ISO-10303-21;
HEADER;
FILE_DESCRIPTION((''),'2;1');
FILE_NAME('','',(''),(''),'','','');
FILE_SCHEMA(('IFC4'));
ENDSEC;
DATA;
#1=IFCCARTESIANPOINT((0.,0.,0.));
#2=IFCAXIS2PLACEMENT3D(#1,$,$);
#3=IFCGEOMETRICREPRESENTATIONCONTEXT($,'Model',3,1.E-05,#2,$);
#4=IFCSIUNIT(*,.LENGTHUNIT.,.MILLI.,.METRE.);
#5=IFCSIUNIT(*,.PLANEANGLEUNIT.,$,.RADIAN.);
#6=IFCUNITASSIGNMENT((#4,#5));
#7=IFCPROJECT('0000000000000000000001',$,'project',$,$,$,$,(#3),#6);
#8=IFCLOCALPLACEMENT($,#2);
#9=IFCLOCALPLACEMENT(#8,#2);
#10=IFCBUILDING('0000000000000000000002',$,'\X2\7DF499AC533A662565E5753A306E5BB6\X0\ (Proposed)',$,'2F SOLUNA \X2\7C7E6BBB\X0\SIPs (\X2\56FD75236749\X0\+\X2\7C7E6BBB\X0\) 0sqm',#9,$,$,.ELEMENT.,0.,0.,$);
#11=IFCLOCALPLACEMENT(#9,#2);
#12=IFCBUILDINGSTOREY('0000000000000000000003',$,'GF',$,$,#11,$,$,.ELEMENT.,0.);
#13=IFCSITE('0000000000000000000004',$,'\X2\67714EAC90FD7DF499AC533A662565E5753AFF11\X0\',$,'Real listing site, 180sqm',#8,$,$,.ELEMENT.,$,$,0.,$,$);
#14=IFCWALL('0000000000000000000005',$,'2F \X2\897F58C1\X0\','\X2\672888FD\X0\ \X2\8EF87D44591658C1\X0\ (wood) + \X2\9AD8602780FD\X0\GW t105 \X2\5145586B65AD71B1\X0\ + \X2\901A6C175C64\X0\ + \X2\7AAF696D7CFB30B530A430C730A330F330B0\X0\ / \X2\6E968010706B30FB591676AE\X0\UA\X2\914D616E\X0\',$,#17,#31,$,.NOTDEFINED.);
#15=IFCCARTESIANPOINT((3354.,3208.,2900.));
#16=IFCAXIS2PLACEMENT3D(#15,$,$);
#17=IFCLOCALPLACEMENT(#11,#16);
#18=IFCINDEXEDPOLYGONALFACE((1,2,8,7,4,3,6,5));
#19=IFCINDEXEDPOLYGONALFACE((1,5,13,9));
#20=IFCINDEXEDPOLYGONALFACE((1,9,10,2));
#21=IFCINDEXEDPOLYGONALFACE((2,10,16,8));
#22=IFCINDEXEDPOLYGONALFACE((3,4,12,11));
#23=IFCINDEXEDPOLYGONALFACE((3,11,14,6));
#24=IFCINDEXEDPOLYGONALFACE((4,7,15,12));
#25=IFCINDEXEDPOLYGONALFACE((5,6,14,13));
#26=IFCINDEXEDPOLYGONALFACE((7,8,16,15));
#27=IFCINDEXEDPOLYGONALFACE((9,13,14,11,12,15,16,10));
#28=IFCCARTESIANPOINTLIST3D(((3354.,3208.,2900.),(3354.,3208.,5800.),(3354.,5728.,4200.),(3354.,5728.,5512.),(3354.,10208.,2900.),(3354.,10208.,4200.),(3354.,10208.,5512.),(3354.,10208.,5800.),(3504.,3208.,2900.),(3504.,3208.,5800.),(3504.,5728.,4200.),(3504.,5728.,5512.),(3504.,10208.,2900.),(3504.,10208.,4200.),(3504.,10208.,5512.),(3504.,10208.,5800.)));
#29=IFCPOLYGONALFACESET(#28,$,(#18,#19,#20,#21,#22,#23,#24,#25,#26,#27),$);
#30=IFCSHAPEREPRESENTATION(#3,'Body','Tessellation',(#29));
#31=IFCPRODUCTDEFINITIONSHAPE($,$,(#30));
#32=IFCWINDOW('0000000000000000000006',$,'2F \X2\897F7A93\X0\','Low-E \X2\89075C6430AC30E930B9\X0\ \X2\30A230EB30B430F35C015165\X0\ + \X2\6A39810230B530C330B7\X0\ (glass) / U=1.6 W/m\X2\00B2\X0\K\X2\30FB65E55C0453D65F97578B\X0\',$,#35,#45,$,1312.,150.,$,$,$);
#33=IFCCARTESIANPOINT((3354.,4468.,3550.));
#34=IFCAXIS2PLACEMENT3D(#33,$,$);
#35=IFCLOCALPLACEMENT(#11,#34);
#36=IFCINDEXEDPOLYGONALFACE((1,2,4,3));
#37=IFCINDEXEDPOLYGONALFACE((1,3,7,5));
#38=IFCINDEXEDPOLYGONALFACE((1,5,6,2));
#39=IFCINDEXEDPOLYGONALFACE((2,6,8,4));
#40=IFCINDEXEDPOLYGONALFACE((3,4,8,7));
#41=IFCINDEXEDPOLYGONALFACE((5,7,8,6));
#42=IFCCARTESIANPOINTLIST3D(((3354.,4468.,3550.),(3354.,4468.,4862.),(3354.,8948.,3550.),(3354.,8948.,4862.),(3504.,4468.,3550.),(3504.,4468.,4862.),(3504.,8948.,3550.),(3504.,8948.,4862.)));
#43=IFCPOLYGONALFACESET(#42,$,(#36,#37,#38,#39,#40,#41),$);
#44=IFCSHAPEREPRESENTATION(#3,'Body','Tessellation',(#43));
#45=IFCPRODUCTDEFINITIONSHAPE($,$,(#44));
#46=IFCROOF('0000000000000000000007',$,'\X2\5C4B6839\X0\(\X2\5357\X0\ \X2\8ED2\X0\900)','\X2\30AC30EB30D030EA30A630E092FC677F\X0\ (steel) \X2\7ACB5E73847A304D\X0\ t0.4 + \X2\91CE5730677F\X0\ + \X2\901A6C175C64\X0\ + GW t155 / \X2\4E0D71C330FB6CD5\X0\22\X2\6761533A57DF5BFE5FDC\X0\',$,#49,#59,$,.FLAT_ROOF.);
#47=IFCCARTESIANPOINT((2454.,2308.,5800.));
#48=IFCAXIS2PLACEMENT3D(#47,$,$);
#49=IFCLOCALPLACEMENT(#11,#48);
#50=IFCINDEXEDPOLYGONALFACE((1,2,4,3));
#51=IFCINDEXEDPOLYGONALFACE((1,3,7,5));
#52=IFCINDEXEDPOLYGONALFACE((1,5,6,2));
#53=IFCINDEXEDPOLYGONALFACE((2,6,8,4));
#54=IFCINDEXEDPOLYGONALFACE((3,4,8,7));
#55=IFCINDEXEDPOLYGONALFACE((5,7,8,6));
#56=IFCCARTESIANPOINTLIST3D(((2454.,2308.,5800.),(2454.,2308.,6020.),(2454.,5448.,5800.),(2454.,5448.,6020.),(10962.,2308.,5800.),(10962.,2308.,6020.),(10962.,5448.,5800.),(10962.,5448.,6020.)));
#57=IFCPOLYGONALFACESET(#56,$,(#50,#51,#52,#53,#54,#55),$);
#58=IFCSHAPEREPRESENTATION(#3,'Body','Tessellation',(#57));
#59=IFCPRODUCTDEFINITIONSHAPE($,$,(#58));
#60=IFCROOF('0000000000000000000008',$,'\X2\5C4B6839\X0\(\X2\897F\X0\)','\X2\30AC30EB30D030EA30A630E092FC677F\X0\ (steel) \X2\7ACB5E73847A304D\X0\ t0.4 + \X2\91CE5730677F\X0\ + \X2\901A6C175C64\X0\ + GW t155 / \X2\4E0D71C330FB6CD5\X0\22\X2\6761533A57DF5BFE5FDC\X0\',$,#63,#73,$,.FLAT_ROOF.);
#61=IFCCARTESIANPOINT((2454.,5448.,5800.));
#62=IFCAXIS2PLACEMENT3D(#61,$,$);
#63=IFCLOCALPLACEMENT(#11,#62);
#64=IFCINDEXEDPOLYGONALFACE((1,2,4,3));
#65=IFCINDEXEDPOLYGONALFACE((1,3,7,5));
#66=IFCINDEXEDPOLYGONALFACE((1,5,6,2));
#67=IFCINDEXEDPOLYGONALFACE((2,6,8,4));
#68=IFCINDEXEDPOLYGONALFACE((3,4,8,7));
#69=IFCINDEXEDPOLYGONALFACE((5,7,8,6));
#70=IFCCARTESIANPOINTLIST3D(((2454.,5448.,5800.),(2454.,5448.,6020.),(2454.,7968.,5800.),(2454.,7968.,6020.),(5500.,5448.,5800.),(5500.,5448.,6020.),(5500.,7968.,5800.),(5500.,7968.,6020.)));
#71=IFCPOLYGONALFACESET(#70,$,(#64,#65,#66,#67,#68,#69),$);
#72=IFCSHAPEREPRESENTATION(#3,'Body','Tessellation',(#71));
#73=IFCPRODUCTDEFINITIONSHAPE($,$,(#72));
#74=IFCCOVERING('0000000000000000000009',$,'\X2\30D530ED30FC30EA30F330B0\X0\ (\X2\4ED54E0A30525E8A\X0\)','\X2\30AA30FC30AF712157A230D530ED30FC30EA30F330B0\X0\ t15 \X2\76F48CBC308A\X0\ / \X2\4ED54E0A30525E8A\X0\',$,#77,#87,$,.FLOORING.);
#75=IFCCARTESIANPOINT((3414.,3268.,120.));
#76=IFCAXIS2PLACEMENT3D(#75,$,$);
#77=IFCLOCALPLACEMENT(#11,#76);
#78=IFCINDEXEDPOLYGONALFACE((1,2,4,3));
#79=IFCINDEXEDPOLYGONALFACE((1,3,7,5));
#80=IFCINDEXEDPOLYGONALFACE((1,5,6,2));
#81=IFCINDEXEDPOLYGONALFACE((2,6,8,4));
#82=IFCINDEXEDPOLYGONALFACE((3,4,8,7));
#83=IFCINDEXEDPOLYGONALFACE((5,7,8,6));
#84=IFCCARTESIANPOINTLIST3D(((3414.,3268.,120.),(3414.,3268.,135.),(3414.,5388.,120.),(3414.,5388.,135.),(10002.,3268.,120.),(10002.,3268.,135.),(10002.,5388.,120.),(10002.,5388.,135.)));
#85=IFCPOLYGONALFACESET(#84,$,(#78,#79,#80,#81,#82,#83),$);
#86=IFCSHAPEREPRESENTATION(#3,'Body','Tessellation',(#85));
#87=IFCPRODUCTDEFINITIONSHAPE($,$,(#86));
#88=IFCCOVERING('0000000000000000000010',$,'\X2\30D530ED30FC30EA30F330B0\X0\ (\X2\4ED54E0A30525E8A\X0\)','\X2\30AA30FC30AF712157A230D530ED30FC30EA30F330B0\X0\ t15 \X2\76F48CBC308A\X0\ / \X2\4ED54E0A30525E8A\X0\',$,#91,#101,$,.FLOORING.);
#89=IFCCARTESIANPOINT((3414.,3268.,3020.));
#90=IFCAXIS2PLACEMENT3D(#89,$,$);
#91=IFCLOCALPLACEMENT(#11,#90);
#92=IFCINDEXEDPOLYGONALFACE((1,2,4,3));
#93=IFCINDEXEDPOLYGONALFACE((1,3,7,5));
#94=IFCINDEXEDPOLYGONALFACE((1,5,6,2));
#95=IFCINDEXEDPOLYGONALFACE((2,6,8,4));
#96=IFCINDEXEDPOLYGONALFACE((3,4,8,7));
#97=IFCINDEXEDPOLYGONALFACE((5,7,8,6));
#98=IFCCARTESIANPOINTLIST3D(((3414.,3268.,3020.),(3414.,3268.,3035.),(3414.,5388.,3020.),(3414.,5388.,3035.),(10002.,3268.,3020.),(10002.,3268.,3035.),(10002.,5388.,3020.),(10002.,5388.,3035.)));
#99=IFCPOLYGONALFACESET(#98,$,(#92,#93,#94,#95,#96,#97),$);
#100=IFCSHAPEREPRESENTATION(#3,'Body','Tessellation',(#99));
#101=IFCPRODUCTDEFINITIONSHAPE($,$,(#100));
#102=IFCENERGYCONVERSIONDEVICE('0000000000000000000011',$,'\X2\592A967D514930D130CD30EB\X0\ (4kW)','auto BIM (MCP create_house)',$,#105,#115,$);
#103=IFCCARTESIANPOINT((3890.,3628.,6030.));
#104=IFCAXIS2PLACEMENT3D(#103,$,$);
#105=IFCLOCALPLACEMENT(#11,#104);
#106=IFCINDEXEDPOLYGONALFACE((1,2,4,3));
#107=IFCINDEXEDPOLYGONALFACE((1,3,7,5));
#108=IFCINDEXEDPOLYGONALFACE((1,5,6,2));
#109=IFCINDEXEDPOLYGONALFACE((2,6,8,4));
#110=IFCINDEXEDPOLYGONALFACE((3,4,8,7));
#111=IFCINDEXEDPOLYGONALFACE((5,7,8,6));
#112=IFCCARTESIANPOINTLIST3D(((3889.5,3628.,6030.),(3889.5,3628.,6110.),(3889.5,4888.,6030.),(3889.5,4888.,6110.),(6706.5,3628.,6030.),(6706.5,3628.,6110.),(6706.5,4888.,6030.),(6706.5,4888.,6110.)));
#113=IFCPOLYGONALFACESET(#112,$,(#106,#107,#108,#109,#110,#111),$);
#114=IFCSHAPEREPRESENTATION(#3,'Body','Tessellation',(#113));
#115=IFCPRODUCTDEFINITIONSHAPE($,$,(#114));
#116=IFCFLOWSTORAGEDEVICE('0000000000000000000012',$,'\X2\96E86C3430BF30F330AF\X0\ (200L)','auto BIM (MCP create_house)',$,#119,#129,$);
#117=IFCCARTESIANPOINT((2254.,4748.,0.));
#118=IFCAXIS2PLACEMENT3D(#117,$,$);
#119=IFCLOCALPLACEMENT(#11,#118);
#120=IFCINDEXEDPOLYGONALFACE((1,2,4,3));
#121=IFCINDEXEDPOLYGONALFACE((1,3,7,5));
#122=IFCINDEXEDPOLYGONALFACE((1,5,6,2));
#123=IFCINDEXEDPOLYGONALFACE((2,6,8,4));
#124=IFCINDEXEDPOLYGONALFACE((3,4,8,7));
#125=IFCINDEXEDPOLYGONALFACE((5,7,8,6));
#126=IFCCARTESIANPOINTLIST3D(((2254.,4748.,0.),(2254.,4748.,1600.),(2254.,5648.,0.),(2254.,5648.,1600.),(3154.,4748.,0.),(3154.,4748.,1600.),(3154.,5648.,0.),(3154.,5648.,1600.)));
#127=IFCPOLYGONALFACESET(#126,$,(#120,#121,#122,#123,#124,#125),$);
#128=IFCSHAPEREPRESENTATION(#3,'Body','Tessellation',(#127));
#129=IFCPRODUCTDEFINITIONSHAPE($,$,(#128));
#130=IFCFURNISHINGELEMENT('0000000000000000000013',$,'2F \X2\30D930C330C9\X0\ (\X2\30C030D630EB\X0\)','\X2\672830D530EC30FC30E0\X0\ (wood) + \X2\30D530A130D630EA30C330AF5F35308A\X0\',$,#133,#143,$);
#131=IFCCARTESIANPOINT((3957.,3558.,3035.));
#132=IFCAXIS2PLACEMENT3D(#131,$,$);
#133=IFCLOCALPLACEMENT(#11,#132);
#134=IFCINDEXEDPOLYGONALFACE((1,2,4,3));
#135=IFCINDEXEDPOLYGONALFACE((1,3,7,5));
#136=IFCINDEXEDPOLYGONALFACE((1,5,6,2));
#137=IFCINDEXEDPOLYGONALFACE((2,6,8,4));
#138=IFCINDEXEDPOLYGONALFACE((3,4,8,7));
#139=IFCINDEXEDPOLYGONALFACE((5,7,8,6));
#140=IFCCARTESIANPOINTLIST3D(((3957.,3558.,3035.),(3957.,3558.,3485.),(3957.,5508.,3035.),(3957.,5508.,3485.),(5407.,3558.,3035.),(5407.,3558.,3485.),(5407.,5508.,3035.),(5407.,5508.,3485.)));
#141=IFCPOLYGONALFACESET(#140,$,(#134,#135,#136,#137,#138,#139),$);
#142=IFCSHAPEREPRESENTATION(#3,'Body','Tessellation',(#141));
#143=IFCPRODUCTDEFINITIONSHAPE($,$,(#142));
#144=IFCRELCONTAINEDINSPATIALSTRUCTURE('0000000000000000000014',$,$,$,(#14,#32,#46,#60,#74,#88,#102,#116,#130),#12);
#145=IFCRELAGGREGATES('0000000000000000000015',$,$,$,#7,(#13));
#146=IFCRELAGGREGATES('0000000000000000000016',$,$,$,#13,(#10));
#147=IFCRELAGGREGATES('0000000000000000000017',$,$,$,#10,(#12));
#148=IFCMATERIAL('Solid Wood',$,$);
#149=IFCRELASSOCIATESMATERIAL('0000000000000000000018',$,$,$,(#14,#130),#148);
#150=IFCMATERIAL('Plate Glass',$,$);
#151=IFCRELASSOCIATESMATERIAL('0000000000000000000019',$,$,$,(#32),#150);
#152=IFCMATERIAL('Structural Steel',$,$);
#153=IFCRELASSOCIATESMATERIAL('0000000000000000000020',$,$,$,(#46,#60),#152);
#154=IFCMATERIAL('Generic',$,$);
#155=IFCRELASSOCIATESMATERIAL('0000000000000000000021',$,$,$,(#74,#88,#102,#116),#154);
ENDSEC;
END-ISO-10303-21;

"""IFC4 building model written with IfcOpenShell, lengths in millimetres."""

from ifc_helpers import new_model, si_unit, frame, frame_2d, origin, place, context, project, spatial, rectangle, extrude, material, element, fill, save


model = new_model("IFC4")

# Units and contexts
model_context = context("Model", 3, precision=1e-05, world=origin())
ifc_project = project(units=[si_unit("LENGTHUNIT", "METRE", prefix="MILLI"), si_unit("PLANEANGLEUNIT", "RADIAN")], contexts=[model_context])

# Site, building, storey
site_placement = place(None, origin())
site = spatial("IfcSite", under=ifc_project, at=site_placement, Name="東京都練馬区春日町１", ObjectType="Real listing site, 180sqm", CompositionType="ELEMENT", RefElevation=0.0)
building_placement = place(site_placement, origin())
building = spatial("IfcBuilding", under=site, at=building_placement, Name="練馬区春日町の家 (Proposed)", ObjectType="2F SOLUNA 籾殻SIPs (国産杉+籾殻) 0sqm", CompositionType="ELEMENT", ElevationOfRefHeight=0.0, ElevationOfTerrain=0.0)
storey_placement = place(building_placement, origin())
storey = spatial("IfcBuildingStorey", under=building, at=storey_placement, Name="GF", CompositionType="ELEMENT", Elevation=0.0)

# Shared definitions
ifc_material_1 = material(Name="Solid Wood")

# Shared definitions
ifc_material_2 = material(Name="Plate Glass")

# Wall, opening, window
wall_1_placement = place(storey_placement, frame((3354.0, 3208.0, 2900.0)))
wall_1 = element("IfcWall", 1, at=wall_1_placement, inside=storey, material=ifc_material_1, Name="2F 西壁", Description="木製 軸組外壁 (wood) + 高性能GW t105 充填断熱 + 通気層 + 窯業系サイディング / 準耐火・外皮UA配慮", PredefinedType="NOTDEFINED", context=model_context, shape_type="SweptSolid", body=[
    extrude(rectangle(XDim=150.0, YDim=7000.0, at=frame_2d((75.0, 3500.0))), frame((3354.0, 3208.0, 2900.0)), (0.0, 0.0, 1.0), 2900.0),
])
opening_1_placement = place(storey_placement, frame((3354.0, 4468.0, 3550.0)))
opening_1 = element("IfcOpeningElement", 2, at=opening_1_placement, cuts=wall_1, PredefinedType="NOTDEFINED", context=model_context, shape_type="SweptSolid", body=[
    extrude(rectangle(XDim=150.0, YDim=4480.0, at=frame_2d((75.0, 2240.0))), frame((3354.0, 4468.0, 3550.0)), (0.0, 0.0, 1.0), 1312.0),
])
window_1_placement = place(storey_placement, frame((3354.0, 4468.0, 3550.0)))
window_1 = element("IfcWindow", 3, at=window_1_placement, inside=storey, material=ifc_material_2, Name="2F 西窓", Description="Low-E 複層ガラス アルゴン封入 + 樹脂サッシ (glass) / U=1.6 W/m²K・日射取得型", OverallHeight=1312.0, OverallWidth=150.0, context=model_context, shape_type="SweptSolid", body=[
    extrude(rectangle(XDim=150.0, YDim=4480.0, at=frame_2d((75.0, 2240.0))), frame((3354.0, 4468.0, 3550.0)), (0.0, 0.0, 1.0), 1312.0),
])
fill(opening_1, window_1)

# Roofs
ifc_material_3 = material(Name="Structural Steel")
roof_1_placement = place(storey_placement, frame((2454.0, 2308.0, 5800.0)))
element("IfcRoof", 4, at=roof_1_placement, inside=storey, material=ifc_material_3, Name="屋根(南 軒900)", Description="ガルバリウム鋼板 (steel) 立平葺き t0.4 + 野地板 + 通気層 + GW t155 / 不燃・法22条区域対応", PredefinedType="FLAT_ROOF", context=model_context, shape_type="SweptSolid", body=[
    extrude(rectangle(XDim=8508.0, YDim=3140.0, at=frame_2d((4254.0, 1570.0))), frame((2454.0, 2308.0, 5800.0)), (0.0, 0.0, 1.0), 220.0),
])
roof_2_placement = place(storey_placement, frame((2454.0, 5448.0, 5800.0)))
element("IfcRoof", 5, at=roof_2_placement, inside=storey, material=ifc_material_3, Name="屋根(西)", Description="ガルバリウム鋼板 (steel) 立平葺き t0.4 + 野地板 + 通気層 + GW t155 / 不燃・法22条区域対応", PredefinedType="FLAT_ROOF", context=model_context, shape_type="SweptSolid", body=[
    extrude(rectangle(XDim=3046.0, YDim=2520.0, at=frame_2d((1523.0, 1260.0))), frame((2454.0, 5448.0, 5800.0)), (0.0, 0.0, 1.0), 220.0),
])

# Coverings
ifc_material_4 = material(Name="Generic")
covering_1_placement = place(storey_placement, frame((3414.0, 3268.0, 120.0)))
element("IfcCovering", 6, at=covering_1_placement, inside=storey, material=ifc_material_4, Name="フローリング (仕上げ床)", Description="オーク無垢フローリング t15 直貼り / 仕上げ床", PredefinedType="FLOORING", context=model_context, shape_type="SweptSolid", body=[
    extrude(rectangle(XDim=6588.0, YDim=2120.0, at=frame_2d((3294.0, 1060.0))), frame((3414.0, 3268.0, 120.0)), (0.0, 0.0, 1.0), 15.0),
])
covering_2_placement = place(storey_placement, frame((3414.0, 3268.0, 3020.0)))
element("IfcCovering", 7, at=covering_2_placement, inside=storey, material=ifc_material_4, Name="フローリング (仕上げ床)", Description="オーク無垢フローリング t15 直貼り / 仕上げ床", PredefinedType="FLOORING", context=model_context, shape_type="SweptSolid", body=[
    extrude(rectangle(XDim=6588.0, YDim=2120.0, at=frame_2d((3294.0, 1060.0))), frame((3414.0, 3268.0, 3020.0)), (0.0, 0.0, 1.0), 15.0),
])

# Energy conversion device
energy_conversion_device_placement = place(storey_placement, frame((3890.0, 3628.0, 6030.0)))
element("IfcEnergyConversionDevice", 8, at=energy_conversion_device_placement, inside=storey, material=ifc_material_4, Name="太陽光パネル (4kW)", Description="auto BIM (MCP create_house)", context=model_context, shape_type="SweptSolid", body=[
    extrude(rectangle(XDim=2817.0, YDim=1260.0, at=frame_2d((1408.0, 630.0))), frame((3890.0, 3628.0, 6030.0)), (0.0, 0.0, 1.0), 80.0),
])

# Flow storage device
flow_storage_device_placement = place(storey_placement, frame((2254.0, 4748.0, 0.0)))
element("IfcFlowStorageDevice", 9, at=flow_storage_device_placement, inside=storey, material=ifc_material_4, Name="雨水タンク (200L)", Description="auto BIM (MCP create_house)", context=model_context, shape_type="SweptSolid", body=[
    extrude(rectangle(XDim=900.0, YDim=900.0, at=frame_2d((450.0, 450.0))), frame((2254.0, 4748.0, 0.0)), (0.0, 0.0, 1.0), 1600.0),
])

# Furnishing element
furnishing_placement = place(storey_placement, frame((3957.0, 3558.0, 3035.0)))
element("IfcFurnishingElement", 10, at=furnishing_placement, inside=storey, material=ifc_material_1, Name="2F ベッド (ダブル)", Description="木フレーム (wood) + ファブリック張り", context=model_context, shape_type="SweptSolid", body=[
    extrude(rectangle(XDim=1450.0, YDim=1950.0, at=frame_2d((725.0, 975.0))), frame((3957.0, 3558.0, 3035.0)), (0.0, 0.0, 1.0), 450.0),
])

save(model, "model.ifc")
